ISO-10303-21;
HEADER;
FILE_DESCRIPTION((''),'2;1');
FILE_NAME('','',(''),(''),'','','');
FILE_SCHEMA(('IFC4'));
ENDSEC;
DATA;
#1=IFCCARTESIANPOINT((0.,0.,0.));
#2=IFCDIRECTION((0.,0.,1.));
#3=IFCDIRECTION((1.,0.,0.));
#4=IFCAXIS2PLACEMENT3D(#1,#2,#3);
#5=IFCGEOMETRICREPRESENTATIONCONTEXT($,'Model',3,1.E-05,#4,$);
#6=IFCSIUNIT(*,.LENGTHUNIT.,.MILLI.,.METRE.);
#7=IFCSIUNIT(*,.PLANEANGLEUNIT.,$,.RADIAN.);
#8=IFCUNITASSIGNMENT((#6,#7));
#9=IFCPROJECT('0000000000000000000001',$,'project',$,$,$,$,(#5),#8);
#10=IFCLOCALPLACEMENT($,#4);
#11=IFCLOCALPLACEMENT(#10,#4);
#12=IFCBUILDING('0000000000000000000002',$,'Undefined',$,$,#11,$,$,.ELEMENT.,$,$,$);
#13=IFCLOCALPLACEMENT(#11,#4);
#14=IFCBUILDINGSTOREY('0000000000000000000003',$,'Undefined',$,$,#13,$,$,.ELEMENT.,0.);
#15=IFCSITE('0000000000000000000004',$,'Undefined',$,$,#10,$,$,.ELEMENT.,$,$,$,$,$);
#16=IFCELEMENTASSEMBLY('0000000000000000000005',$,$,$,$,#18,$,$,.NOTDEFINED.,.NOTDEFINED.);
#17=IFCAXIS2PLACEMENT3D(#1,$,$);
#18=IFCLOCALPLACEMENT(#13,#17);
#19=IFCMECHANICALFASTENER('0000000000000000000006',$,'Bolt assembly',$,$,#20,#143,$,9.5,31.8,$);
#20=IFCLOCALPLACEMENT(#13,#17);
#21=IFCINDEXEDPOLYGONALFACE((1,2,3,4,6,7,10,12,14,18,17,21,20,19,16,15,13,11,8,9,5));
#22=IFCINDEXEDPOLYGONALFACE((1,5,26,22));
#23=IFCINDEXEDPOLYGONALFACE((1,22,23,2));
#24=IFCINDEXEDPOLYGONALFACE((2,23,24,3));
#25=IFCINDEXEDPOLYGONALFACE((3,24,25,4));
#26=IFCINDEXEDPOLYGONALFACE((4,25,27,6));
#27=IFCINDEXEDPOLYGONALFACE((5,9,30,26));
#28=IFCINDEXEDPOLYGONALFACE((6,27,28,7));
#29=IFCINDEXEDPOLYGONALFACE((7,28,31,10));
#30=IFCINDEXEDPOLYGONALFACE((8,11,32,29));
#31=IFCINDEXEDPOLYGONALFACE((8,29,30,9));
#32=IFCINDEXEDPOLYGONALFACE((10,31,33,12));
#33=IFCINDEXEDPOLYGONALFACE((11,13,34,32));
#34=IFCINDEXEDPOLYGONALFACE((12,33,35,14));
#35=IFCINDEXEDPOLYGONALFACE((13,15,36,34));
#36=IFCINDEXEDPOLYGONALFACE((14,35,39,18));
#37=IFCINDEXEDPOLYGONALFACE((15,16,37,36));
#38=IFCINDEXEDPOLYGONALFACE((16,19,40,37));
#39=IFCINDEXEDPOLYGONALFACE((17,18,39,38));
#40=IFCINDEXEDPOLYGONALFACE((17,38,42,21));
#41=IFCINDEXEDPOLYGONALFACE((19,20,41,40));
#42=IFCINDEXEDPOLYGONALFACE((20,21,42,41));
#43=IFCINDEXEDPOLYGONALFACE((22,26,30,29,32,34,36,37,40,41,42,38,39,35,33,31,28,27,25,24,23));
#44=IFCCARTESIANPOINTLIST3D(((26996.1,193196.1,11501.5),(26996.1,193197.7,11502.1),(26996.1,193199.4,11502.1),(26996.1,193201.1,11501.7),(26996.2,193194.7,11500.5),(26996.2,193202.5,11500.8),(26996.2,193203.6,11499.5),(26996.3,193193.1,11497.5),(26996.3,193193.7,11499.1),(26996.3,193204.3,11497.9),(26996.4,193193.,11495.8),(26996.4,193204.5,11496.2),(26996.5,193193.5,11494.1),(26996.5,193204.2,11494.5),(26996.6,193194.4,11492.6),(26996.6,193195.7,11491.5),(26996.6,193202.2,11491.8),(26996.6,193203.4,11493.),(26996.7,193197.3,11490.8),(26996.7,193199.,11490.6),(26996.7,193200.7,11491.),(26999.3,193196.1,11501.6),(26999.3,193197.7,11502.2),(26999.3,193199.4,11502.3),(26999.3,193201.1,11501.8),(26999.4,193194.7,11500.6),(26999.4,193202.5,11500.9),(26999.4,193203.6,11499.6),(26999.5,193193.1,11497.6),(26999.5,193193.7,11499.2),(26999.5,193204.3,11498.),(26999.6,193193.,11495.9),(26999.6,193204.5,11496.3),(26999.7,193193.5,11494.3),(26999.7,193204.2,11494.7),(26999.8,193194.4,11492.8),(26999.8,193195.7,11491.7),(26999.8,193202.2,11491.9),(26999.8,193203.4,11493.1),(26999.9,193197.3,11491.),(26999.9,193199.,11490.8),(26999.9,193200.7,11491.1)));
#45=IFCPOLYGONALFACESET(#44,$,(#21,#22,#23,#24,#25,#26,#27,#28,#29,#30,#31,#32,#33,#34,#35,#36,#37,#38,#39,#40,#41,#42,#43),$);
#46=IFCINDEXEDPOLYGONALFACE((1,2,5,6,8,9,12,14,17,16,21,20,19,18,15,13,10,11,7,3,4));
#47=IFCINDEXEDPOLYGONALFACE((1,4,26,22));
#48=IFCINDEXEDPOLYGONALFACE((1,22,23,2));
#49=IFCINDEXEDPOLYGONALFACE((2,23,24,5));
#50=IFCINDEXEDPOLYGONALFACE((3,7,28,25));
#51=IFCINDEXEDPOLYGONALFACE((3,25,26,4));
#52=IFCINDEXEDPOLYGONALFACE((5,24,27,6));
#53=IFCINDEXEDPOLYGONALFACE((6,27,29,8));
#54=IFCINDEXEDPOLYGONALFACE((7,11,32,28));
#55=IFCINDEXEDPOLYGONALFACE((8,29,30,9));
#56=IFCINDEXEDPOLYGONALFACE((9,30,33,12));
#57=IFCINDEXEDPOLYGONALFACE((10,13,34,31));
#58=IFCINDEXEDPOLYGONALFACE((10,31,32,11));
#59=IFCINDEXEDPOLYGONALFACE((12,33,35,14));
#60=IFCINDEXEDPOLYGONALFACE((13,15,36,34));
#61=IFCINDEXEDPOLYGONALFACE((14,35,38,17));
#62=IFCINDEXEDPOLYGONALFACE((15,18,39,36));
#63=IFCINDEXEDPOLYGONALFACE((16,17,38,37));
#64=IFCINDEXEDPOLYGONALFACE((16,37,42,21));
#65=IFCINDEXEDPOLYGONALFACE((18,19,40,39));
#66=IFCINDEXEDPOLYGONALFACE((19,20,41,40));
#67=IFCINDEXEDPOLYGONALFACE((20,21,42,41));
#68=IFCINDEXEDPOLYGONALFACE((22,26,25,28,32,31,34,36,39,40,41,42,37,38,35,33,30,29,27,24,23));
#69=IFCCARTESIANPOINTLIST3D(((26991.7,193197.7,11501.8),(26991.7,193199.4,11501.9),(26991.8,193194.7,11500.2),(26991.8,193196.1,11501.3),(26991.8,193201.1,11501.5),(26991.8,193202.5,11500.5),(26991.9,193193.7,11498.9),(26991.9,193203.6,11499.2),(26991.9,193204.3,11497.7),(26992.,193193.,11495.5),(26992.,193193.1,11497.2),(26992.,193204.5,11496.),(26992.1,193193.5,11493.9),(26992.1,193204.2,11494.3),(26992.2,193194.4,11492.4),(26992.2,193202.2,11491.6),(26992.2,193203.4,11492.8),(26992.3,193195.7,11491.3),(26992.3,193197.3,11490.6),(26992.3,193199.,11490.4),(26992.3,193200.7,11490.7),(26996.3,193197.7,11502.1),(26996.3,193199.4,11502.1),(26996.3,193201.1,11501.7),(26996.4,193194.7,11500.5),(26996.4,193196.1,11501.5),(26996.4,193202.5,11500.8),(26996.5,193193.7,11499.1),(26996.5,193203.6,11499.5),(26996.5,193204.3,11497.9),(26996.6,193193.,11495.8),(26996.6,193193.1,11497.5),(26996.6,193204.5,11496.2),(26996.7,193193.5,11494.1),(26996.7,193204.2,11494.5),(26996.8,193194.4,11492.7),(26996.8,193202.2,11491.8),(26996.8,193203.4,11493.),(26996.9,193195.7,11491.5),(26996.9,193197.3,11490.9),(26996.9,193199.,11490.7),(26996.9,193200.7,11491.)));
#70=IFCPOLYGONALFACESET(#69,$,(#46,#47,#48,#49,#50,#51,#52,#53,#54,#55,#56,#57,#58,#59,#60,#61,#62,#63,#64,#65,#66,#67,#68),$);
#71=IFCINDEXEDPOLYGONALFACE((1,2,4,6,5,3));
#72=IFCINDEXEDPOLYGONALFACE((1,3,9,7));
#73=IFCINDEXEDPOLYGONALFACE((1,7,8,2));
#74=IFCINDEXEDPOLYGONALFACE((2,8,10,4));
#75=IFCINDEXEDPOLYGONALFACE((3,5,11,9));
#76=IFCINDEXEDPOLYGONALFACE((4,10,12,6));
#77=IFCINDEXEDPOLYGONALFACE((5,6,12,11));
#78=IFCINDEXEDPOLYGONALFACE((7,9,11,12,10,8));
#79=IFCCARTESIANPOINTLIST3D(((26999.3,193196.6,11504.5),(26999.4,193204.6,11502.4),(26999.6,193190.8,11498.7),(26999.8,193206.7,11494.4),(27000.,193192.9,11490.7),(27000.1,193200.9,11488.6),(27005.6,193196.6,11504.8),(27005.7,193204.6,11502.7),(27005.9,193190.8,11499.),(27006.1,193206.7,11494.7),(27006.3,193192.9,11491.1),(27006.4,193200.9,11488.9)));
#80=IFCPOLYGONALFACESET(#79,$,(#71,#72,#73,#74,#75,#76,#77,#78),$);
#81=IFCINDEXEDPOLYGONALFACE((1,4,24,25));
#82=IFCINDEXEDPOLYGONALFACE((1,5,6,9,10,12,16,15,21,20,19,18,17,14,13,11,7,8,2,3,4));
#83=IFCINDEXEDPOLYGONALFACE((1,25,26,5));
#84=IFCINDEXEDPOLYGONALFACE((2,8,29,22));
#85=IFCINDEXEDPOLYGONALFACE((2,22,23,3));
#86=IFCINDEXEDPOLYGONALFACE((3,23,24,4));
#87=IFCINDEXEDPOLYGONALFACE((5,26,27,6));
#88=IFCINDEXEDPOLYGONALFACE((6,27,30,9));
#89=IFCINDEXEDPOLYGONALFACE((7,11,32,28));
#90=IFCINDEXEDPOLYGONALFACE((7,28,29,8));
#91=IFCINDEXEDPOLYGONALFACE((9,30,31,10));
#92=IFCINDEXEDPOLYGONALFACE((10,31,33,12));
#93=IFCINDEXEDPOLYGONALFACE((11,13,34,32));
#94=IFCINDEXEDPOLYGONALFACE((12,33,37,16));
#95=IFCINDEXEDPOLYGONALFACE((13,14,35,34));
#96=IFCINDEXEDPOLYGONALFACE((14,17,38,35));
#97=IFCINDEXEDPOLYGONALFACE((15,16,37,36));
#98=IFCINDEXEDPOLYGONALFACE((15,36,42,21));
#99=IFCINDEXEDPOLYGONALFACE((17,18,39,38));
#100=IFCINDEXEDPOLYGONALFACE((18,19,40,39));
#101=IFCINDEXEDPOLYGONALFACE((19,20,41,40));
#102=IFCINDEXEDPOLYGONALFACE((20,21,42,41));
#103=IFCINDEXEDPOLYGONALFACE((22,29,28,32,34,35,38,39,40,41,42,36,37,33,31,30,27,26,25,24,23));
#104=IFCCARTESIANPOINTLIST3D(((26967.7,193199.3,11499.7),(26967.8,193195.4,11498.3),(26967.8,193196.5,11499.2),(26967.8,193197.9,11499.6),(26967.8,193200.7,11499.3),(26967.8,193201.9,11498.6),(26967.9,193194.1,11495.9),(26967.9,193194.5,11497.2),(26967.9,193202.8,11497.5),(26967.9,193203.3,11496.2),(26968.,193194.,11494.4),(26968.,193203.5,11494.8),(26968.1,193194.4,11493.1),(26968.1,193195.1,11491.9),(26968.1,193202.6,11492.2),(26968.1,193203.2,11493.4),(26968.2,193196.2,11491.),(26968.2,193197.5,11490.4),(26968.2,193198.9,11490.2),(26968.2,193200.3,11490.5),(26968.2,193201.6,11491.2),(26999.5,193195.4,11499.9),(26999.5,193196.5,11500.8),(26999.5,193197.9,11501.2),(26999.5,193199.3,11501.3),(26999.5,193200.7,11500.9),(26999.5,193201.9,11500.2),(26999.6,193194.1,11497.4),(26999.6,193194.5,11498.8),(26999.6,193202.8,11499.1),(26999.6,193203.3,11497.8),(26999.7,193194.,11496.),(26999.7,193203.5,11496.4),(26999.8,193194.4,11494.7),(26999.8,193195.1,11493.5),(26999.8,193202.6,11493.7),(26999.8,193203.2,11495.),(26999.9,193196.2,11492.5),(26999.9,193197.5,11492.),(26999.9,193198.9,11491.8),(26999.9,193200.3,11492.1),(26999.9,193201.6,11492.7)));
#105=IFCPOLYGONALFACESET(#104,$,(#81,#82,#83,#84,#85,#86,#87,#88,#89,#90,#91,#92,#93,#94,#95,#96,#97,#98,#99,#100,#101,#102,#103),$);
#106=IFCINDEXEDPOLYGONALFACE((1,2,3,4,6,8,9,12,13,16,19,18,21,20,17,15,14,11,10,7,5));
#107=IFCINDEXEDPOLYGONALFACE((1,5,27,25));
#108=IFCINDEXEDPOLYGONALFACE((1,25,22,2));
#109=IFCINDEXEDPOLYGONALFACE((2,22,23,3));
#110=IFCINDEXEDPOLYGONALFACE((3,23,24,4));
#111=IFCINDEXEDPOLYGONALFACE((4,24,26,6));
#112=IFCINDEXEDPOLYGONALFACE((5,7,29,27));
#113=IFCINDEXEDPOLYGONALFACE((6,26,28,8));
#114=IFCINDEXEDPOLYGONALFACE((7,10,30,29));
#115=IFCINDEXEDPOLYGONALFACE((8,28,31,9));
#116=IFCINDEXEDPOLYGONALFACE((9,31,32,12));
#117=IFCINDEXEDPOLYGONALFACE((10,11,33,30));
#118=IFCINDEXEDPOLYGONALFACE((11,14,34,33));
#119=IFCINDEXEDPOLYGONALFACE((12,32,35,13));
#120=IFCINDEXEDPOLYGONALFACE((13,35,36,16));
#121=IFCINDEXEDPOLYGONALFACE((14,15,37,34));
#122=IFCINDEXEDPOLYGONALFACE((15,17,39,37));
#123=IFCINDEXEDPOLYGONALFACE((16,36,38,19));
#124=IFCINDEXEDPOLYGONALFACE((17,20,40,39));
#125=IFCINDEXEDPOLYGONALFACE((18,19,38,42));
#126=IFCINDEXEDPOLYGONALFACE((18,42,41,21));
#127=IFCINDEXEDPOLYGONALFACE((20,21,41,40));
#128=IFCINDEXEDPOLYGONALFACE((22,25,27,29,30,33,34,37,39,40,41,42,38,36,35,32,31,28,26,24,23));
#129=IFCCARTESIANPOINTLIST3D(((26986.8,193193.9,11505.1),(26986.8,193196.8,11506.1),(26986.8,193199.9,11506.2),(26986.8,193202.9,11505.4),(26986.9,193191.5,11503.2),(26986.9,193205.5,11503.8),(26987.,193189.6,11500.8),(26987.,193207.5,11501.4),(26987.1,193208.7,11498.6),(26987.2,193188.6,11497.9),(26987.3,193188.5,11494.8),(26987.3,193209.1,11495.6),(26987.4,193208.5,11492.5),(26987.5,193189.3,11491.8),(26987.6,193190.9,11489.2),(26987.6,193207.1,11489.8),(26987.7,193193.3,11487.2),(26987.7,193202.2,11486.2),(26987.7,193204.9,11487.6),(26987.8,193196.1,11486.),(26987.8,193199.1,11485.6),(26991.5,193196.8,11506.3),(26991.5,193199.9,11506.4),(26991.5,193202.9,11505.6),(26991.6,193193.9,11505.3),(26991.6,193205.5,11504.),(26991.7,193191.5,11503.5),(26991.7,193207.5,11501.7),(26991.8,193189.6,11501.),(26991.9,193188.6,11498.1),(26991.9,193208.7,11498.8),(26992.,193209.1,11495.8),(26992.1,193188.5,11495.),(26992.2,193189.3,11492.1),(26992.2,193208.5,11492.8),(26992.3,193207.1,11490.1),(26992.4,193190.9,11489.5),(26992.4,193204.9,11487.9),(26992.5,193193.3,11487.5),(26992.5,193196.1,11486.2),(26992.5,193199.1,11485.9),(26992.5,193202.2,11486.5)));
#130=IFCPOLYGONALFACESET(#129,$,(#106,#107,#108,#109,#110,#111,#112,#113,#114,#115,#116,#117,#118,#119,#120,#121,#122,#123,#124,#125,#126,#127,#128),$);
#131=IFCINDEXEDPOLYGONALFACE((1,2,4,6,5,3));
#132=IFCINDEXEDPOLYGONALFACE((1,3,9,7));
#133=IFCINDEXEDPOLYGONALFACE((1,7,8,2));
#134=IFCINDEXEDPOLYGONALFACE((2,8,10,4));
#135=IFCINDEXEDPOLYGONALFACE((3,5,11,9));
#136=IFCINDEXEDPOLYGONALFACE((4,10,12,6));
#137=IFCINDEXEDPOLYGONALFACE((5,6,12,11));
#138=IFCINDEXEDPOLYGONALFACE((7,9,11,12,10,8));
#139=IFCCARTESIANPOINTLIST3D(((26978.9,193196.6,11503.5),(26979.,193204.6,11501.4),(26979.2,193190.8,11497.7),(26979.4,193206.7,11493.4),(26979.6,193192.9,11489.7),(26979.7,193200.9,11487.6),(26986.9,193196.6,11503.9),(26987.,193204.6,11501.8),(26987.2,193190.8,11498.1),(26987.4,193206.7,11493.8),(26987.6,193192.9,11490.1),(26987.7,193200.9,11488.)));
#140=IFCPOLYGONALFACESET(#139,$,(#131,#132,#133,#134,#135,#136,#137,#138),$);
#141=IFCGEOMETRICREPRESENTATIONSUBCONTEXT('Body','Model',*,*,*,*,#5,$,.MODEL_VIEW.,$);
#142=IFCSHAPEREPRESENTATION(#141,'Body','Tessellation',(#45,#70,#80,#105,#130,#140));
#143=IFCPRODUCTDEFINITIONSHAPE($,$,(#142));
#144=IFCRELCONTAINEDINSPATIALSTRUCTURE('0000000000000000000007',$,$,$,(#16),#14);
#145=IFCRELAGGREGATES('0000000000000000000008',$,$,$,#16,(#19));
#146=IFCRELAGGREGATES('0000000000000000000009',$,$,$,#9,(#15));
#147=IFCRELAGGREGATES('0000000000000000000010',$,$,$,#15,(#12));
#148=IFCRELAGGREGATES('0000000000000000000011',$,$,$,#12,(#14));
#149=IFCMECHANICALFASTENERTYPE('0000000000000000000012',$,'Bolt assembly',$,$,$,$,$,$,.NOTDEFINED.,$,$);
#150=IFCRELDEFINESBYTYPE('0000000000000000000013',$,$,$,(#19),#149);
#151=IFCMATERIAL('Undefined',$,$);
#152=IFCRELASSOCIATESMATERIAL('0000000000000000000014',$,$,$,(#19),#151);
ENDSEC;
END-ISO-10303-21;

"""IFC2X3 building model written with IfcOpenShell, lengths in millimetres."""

from ifc_helpers import new_model, si_unit, frame, origin_with_axes, origin_2d_with_axis, place, context, subcontext, project, spatial, polyline, circle, outline, extrude, source, transform, mapped, material, type_object, element, aggregate, save


model = new_model("IFC2X3")

# Units and contexts
model_context = context("Model", 3, precision=1e-05, world=origin_with_axes())
body_context = subcontext(model_context, "Body", "Model", "MODEL_VIEW")
ifc_project = project(units=[si_unit("LENGTHUNIT", "METRE", prefix="MILLI"), si_unit("PLANEANGLEUNIT", "RADIAN")], contexts=[model_context])

# Site, building, storey
site_placement = place(None, origin_with_axes())
site = spatial("IfcSite", under=ifc_project, at=site_placement, Name="Undefined", CompositionType="ELEMENT")
building_placement = place(site_placement, origin_with_axes())
building = spatial("IfcBuilding", under=site, at=building_placement, Name="Undefined", CompositionType="ELEMENT")
storey_placement = place(building_placement, origin_with_axes())
storey = spatial("IfcBuildingStorey", under=building, at=storey_placement, Name="Undefined", CompositionType="ELEMENT", Elevation=0.0)

# Element assembly
assembly_1_placement = place(storey_placement, origin_with_axes())
assembly_1 = element("IfcElementAssembly", 1, at=assembly_1_placement, inside=storey, AssemblyPlace="NOTDEFINED", PredefinedType="NOTDEFINED")

# Mechanical fastener
ifc_material_1 = material(Name="Undefined")
mechanical_fastener_type = type_object("IfcMechanicalFastenerType", Name="Bolt assembly")
shared_shape_1 = source(origin_with_axes(), body_context, "Body", "SweptSolid", [
    extrude(circle(Radius=5.8, at=origin_2d_with_axis()), frame((0.0, -7.6, 0.0), z_axis=(0.0, 1.0, 0.0), x_axis=(1.0, 0.0, 0.0)), (0.0, 0.0, 1.0), 3.2),
    extrude(circle(Radius=5.8, at=origin_2d_with_axis()), frame((0.0, -4.6, 0.0), z_axis=(0.0, 1.0, 0.0), x_axis=(1.0, 0.0, 0.0)), (0.0, 0.0, 1.0), 4.6),
    extrude(outline(polyline([(7.1, -4.1), (7.1, 4.1), (0.0, 8.2), (-7.1, 4.1), (-7.1, -4.1), (0.0, -8.2), (7.1, -4.1)])), frame((0.0, -14.0, 0.0), z_axis=(0.0, 1.0, 0.0), x_axis=(1.0, 0.0, 0.0)), (0.0, 0.0, 1.0), 6.3),
    extrude(circle(Radius=4.8, at=origin_2d_with_axis()), frame((0.0, -7.7, 0.0), z_axis=(0.0, 1.0, 0.0), x_axis=(1.0, 0.0, 0.0)), (0.0, 0.0, 1.0), 31.8),
    extrude(circle(Radius=10.3, at=origin_2d_with_axis()), frame((0.0, 0.0, 0.0), z_axis=(0.0, 1.0, 0.0), x_axis=(1.0, 0.0, 0.0)), (0.0, 0.0, 1.0), 4.8),
    extrude(outline(polyline([(7.1, -4.1), (7.1, 4.1), (0.0, 8.2), (-7.1, 4.1), (-7.1, -4.1), (0.0, -8.2), (7.1, -4.1)])), frame((0.0, 4.8, 0.0), z_axis=(0.0, 1.0, 0.0), x_axis=(1.0, 0.0, 0.0)), (0.0, 0.0, 1.0), 7.9),
])
mechanical_fastener_1_placement = place(assembly_1_placement, frame((26992.0, 193198.8, 11496.2), z_axis=(0.035282, -0.707107, -0.706226), x_axis=(-0.035282, -0.707107, 0.706226)))
mechanical_fastener_1 = element("IfcMechanicalFastener", 2, at=mechanical_fastener_1_placement, type_object=mechanical_fastener_type, material=ifc_material_1, Name="Bolt assembly", NominalDiameter=9.5, NominalLength=31.8, context=body_context, shape_type="MappedRepresentation", body=[
    mapped(shared_shape_1, transform((0.0, 0.0, 0.0))),
])

aggregate(assembly_1, [mechanical_fastener_1])

save(model, "model.ifc")
